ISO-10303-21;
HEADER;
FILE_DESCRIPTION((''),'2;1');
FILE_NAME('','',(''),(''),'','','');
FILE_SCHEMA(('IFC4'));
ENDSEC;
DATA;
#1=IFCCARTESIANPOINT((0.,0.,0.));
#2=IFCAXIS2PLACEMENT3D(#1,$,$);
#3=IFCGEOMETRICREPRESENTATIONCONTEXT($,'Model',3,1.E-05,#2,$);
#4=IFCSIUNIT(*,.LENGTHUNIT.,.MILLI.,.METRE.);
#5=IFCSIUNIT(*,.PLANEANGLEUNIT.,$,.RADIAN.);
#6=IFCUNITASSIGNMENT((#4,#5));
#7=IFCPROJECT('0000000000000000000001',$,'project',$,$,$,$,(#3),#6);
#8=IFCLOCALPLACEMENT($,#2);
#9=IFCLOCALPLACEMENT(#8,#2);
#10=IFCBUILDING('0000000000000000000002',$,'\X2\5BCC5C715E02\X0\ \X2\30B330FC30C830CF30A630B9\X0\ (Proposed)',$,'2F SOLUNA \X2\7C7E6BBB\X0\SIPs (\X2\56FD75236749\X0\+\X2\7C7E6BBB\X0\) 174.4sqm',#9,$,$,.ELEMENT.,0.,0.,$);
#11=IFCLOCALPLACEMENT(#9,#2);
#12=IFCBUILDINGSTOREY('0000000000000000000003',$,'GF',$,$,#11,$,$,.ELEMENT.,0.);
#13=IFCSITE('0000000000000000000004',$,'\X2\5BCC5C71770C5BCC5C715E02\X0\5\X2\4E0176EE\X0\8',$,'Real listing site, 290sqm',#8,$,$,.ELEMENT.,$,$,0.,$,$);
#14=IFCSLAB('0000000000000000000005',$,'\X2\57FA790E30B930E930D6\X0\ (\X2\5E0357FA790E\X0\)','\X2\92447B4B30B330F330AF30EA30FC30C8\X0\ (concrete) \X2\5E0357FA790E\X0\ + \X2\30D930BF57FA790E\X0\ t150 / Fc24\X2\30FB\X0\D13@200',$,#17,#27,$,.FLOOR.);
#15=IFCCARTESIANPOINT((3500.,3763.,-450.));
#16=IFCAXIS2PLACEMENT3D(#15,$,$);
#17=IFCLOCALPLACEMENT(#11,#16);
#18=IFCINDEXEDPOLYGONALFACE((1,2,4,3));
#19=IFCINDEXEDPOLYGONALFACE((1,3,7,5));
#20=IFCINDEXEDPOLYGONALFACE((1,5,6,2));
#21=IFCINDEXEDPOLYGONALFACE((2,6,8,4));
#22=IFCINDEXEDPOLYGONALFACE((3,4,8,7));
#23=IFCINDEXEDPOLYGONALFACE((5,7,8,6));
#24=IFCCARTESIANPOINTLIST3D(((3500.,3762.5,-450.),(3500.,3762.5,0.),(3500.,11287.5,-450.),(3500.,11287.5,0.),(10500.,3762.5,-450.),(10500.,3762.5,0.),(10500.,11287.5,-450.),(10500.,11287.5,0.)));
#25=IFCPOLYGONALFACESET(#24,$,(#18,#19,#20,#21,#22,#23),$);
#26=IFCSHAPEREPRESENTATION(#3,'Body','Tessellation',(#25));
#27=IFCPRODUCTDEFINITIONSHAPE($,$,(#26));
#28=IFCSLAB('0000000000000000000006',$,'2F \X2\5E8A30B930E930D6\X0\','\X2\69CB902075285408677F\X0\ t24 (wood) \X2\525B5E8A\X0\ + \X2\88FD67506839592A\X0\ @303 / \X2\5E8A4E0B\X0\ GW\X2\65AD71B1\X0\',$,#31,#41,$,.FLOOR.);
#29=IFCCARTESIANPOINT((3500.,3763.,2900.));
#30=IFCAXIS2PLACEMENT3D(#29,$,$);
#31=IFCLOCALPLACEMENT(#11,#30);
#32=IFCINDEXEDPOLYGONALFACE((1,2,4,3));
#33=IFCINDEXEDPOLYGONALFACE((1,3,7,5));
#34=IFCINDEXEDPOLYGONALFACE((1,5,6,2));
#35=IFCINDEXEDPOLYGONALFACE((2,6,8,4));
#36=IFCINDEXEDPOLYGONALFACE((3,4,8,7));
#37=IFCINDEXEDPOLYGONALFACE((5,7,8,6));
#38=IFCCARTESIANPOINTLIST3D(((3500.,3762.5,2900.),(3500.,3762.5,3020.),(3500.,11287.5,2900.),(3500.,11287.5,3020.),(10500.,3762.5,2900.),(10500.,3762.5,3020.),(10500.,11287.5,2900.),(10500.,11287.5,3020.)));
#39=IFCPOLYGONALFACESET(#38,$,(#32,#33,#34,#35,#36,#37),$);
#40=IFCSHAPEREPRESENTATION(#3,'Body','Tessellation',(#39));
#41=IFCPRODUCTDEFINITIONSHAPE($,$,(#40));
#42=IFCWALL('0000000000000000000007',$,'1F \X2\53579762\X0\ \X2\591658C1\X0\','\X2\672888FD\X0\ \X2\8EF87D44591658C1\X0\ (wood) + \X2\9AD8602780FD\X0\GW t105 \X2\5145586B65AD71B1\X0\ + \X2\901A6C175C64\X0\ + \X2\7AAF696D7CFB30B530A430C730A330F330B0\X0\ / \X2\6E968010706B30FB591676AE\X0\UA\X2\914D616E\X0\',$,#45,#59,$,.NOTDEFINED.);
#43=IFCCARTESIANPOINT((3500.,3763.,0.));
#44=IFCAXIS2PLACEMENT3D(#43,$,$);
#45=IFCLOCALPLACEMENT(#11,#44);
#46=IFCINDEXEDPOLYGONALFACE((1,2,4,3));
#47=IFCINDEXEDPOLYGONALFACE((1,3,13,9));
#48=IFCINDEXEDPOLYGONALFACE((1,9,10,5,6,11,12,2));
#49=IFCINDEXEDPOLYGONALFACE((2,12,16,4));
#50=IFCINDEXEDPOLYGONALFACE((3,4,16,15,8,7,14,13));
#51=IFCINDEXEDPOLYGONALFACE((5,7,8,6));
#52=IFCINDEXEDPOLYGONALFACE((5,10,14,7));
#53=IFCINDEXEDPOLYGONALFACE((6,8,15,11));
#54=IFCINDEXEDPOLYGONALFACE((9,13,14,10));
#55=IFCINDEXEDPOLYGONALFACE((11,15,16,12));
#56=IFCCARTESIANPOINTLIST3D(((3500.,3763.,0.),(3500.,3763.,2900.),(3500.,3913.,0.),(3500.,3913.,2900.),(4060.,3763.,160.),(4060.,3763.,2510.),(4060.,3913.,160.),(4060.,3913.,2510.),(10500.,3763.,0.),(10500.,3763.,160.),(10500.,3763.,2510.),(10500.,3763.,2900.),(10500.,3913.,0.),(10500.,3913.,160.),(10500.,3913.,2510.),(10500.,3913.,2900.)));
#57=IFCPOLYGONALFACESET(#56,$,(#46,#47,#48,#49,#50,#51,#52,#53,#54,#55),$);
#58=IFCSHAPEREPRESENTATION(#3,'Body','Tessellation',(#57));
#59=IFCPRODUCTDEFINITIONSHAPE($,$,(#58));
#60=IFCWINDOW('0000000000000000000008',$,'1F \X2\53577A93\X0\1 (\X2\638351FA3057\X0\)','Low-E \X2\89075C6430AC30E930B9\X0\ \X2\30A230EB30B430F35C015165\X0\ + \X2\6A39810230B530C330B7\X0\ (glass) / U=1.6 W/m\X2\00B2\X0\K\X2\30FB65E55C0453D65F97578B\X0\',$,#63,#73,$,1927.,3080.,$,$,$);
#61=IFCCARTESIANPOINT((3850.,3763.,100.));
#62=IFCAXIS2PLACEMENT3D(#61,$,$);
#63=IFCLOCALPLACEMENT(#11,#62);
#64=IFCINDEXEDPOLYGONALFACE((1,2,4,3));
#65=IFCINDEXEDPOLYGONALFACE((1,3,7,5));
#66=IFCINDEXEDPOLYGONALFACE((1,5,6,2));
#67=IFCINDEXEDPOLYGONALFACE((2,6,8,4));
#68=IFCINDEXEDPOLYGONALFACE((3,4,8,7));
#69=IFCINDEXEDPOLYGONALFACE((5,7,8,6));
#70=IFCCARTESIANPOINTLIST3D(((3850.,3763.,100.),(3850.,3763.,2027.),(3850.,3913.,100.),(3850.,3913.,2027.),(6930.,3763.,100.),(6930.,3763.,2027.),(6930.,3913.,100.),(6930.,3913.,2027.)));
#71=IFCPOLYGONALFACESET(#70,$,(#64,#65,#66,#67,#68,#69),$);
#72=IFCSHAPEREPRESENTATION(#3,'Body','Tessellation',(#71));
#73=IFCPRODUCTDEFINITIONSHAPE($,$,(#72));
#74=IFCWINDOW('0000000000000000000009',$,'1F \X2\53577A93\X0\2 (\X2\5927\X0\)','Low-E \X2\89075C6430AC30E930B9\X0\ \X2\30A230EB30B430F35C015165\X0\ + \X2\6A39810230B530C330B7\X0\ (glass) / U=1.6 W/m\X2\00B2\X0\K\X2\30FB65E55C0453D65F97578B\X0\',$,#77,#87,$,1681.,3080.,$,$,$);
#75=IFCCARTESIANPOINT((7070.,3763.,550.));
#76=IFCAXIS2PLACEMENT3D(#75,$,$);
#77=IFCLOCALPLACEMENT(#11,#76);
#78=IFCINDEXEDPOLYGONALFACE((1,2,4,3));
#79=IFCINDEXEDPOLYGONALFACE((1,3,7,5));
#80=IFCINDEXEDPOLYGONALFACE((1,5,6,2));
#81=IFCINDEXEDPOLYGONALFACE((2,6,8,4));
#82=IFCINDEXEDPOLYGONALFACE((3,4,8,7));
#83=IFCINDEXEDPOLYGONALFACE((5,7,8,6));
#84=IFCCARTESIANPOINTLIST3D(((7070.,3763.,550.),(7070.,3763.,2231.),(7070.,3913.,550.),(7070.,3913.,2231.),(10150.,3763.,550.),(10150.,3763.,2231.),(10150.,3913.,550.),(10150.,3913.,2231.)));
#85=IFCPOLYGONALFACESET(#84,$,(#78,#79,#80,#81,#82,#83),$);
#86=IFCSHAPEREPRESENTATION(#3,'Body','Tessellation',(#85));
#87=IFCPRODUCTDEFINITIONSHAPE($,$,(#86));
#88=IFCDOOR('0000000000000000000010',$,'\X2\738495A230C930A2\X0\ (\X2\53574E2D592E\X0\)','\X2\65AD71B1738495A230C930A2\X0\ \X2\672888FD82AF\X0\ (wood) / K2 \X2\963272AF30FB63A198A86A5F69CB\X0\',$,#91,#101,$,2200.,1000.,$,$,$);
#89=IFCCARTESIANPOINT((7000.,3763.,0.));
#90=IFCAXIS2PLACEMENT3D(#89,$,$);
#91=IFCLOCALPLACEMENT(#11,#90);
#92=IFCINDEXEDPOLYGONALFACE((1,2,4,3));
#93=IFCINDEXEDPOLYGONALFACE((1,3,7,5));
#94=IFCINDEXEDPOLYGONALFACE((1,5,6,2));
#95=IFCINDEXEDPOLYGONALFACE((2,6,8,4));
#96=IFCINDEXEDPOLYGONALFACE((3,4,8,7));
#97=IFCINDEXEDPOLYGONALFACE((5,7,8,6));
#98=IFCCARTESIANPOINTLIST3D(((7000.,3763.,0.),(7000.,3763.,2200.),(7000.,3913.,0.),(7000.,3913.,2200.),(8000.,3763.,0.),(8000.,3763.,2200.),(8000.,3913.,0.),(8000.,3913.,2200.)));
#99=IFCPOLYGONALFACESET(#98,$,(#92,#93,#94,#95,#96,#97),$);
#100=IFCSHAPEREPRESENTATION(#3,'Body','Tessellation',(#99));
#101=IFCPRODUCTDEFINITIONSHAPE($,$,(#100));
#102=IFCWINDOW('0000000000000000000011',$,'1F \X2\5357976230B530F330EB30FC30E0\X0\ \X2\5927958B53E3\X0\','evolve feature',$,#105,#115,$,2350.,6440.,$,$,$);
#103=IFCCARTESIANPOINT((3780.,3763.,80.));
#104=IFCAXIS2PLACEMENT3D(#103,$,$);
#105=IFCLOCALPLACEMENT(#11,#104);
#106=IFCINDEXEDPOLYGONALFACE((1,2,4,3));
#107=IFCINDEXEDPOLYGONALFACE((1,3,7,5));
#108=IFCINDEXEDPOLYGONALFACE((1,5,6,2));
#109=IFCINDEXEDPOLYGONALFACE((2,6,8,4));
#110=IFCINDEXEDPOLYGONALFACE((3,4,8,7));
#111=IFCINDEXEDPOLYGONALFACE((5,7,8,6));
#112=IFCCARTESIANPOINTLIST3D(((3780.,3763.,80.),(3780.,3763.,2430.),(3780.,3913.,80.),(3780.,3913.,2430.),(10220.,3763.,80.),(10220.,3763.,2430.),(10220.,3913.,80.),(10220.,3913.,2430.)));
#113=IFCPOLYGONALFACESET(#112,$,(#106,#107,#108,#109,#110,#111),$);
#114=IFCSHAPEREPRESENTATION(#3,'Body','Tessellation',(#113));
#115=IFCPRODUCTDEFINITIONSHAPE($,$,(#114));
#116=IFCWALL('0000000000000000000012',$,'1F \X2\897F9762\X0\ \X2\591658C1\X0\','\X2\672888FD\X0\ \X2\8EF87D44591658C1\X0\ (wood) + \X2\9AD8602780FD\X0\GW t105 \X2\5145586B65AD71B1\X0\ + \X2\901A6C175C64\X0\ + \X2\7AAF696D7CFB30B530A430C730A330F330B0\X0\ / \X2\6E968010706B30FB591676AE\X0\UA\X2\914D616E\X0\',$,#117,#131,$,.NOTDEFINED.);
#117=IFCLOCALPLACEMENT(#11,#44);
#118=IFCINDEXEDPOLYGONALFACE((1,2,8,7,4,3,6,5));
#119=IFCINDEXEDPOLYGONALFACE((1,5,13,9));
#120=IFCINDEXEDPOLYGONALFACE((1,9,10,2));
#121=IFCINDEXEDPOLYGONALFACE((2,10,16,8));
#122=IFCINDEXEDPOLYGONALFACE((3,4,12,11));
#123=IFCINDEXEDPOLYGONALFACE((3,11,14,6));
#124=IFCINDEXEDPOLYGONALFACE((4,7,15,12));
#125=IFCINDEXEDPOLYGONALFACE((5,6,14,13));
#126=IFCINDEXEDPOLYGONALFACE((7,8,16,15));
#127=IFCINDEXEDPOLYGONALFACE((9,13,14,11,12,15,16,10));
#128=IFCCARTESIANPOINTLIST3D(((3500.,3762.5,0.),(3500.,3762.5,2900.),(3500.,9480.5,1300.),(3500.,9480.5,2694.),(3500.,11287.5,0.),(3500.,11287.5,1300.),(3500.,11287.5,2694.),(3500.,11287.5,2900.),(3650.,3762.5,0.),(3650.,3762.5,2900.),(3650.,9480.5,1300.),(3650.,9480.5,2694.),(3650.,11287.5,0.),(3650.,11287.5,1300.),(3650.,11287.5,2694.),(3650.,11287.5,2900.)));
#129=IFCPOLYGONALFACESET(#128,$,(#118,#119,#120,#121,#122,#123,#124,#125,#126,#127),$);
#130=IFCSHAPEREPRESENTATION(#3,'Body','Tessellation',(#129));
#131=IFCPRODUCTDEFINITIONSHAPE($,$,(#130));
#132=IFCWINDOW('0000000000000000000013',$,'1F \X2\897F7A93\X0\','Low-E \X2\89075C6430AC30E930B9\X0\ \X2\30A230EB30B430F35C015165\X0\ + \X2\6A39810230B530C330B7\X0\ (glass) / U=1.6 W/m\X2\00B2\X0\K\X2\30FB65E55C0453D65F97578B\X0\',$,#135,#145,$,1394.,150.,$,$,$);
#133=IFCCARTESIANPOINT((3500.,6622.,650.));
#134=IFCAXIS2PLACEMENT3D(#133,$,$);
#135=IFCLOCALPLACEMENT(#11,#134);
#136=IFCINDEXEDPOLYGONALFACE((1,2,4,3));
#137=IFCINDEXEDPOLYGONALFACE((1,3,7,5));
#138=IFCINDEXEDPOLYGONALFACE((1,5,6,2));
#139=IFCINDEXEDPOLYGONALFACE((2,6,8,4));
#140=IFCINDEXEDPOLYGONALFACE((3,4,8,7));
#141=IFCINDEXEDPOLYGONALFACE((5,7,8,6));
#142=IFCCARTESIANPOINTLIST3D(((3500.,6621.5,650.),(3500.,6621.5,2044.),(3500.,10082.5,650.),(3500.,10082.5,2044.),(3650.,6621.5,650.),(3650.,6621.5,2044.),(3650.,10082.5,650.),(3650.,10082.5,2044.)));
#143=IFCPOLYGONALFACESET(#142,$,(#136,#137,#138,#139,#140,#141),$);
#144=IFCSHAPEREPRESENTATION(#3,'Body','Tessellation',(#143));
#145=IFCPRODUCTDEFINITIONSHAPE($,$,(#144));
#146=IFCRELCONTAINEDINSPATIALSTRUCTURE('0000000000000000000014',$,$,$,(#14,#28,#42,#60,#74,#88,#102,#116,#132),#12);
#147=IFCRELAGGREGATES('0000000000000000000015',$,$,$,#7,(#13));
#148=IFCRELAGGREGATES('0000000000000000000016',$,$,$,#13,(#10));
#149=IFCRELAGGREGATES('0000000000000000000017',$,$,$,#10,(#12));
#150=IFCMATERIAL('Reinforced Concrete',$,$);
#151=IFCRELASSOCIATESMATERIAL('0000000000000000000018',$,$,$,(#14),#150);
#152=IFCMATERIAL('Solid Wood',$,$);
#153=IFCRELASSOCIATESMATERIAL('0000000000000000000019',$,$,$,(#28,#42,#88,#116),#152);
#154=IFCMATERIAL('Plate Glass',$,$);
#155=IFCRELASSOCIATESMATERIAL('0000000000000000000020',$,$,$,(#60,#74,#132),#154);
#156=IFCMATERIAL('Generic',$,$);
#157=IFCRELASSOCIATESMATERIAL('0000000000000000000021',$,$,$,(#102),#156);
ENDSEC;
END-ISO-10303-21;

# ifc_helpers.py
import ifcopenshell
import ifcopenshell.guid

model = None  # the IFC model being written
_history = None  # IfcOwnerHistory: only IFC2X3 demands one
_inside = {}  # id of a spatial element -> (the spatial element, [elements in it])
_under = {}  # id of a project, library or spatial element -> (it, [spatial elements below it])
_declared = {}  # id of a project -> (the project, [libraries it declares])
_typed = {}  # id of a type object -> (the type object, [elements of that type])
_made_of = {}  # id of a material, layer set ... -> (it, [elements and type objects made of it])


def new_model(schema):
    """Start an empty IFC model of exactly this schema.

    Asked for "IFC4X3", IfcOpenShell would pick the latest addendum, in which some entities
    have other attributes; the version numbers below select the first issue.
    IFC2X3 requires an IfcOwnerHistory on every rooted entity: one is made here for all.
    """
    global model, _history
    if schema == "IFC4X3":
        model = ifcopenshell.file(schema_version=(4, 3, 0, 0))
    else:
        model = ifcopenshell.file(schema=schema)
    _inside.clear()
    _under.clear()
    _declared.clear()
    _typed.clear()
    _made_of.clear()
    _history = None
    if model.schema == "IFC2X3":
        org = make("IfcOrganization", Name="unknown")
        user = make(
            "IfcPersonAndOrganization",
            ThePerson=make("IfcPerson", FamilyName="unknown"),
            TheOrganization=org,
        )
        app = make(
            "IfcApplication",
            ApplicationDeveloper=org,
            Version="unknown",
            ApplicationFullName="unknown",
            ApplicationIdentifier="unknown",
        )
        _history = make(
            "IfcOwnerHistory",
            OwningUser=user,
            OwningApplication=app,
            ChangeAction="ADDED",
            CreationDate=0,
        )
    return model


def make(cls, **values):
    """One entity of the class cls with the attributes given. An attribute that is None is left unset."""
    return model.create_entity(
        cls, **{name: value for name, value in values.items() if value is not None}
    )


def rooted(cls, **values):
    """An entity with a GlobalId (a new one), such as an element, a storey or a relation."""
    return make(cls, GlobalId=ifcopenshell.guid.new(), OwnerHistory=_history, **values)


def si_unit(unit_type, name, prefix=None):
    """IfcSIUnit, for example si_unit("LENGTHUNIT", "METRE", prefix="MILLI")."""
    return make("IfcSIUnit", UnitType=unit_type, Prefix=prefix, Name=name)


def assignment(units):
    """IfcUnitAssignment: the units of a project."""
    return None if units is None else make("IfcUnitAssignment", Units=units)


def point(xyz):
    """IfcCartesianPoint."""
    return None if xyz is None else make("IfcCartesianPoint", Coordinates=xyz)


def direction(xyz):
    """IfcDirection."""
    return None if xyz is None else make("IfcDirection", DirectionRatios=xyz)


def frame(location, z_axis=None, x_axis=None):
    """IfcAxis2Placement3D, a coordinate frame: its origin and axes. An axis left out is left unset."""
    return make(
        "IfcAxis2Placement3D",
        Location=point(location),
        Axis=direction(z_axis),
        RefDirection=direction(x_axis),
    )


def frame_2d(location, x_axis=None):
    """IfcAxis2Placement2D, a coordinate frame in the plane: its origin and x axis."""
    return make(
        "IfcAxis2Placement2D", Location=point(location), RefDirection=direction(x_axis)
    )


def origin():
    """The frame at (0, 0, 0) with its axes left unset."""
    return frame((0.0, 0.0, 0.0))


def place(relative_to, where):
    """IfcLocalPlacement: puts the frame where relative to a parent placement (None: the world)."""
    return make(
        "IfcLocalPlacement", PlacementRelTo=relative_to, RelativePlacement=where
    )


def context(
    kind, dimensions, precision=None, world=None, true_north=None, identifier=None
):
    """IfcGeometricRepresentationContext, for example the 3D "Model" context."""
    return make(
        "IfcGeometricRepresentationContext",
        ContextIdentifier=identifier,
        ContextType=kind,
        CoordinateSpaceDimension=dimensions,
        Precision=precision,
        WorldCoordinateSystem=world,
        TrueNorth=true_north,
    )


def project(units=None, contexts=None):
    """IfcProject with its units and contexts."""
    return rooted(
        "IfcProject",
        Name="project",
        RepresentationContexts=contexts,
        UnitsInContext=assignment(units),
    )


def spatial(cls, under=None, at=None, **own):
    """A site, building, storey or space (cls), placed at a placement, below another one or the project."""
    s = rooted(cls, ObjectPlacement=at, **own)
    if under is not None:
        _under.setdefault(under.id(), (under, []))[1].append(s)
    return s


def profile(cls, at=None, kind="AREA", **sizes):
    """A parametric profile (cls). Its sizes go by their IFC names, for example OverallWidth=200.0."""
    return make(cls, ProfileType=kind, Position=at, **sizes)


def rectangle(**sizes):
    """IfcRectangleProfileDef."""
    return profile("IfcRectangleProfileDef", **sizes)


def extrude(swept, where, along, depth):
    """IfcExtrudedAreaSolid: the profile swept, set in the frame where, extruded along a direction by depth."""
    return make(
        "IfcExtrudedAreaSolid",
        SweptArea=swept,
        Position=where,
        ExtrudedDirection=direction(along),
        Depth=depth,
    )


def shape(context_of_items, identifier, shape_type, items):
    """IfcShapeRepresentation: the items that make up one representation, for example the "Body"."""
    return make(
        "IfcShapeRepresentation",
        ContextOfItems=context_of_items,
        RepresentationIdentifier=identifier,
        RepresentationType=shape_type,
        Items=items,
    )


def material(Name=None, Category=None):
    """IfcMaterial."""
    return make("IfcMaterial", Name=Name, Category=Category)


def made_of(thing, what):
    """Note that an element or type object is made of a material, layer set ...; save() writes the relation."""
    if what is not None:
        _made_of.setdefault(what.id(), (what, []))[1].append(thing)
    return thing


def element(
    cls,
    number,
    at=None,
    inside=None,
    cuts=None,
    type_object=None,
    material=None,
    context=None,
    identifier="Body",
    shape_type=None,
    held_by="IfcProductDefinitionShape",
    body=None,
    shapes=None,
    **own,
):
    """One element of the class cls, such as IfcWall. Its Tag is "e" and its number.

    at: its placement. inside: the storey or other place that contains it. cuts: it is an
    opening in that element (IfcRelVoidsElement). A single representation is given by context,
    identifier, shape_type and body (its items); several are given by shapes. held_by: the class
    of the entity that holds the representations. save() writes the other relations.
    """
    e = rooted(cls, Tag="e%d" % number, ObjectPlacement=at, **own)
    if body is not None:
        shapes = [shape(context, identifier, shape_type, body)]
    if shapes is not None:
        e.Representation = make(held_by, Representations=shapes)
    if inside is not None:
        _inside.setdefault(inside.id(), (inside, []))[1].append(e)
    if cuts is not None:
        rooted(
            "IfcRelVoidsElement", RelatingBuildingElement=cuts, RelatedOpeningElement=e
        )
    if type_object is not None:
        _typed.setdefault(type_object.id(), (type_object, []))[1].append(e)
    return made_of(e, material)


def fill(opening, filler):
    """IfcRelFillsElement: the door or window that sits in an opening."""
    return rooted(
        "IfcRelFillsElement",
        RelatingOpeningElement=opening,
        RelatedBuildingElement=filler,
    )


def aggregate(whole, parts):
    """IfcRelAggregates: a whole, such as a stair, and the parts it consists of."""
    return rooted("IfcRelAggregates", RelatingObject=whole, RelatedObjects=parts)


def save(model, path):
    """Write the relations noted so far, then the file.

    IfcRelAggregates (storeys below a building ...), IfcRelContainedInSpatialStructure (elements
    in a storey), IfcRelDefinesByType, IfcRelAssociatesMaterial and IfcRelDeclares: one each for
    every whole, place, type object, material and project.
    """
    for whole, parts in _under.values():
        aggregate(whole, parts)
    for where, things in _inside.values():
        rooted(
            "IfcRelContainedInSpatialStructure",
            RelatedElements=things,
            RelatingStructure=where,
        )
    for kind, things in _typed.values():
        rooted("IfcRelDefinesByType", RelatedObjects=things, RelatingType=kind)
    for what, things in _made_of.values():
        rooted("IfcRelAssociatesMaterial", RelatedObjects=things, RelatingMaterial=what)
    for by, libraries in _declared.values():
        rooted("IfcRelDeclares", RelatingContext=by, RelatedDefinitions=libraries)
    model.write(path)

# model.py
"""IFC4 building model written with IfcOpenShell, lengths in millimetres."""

from ifc_helpers import new_model, si_unit, frame, frame_2d, origin, place, context, project, spatial, rectangle, extrude, material, element, fill, save


model = new_model("IFC4")

# Units and contexts
model_context = context("Model", 3, precision=1e-05, world=origin())
ifc_project = project(units=[si_unit("LENGTHUNIT", "METRE", prefix="MILLI"), si_unit("PLANEANGLEUNIT", "RADIAN")], contexts=[model_context])

# Site, building, storey
site_placement = place(None, origin())
site = spatial("IfcSite", under=ifc_project, at=site_placement, Name="富山県富山市5丁目8", ObjectType="Real listing site, 290sqm", CompositionType="ELEMENT", RefElevation=0.0)
building_placement = place(site_placement, origin())
building = spatial("IfcBuilding", under=site, at=building_placement, Name="富山市 コートハウス (Proposed)", ObjectType="2F SOLUNA 籾殻SIPs (国産杉+籾殻) 174.4sqm", CompositionType="ELEMENT", ElevationOfRefHeight=0.0, ElevationOfTerrain=0.0)
storey_placement = place(building_placement, origin())
storey = spatial("IfcBuildingStorey", under=building, at=storey_placement, Name="GF", CompositionType="ELEMENT", Elevation=0.0)

# Slabs
ifc_material_1 = material(Name="Reinforced Concrete")
slab_1_placement = place(storey_placement, frame((3500.0, 3763.0, -450.0)))
element("IfcSlab", 1, at=slab_1_placement, inside=storey, material=ifc_material_1, Name="基礎スラブ (布基礎)", Description="鉄筋コンクリート (concrete) 布基礎 + ベタ基礎 t150 / Fc24・D13@200", PredefinedType="FLOOR", context=model_context, shape_type="SweptSolid", body=[
    extrude(rectangle(XDim=7000.0, YDim=7525.0, at=frame_2d((3500.0, 3762.0))), frame((3500.0, 3763.0, -450.0)), (0.0, 0.0, 1.0), 450.0),
])
ifc_material_2 = material(Name="Solid Wood")
slab_2_placement = place(storey_placement, frame((3500.0, 3763.0, 2900.0)))
element("IfcSlab", 2, at=slab_2_placement, inside=storey, material=ifc_material_2, Name="2F 床スラブ", Description="構造用合板 t24 (wood) 剛床 + 製材根太 @303 / 床下 GW断熱", PredefinedType="FLOOR", context=model_context, shape_type="SweptSolid", body=[
    extrude(rectangle(XDim=7000.0, YDim=7525.0, at=frame_2d((3500.0, 3762.0))), frame((3500.0, 3763.0, 2900.0)), (0.0, 0.0, 1.0), 120.0),
])
ifc_material_3 = material(Name="Generic")

# Wall, openings, windows, door
wall_1_placement = place(storey_placement, frame((3500.0, 3763.0, 0.0)))
wall_1 = element("IfcWall", 3, at=wall_1_placement, inside=storey, material=ifc_material_2, Name="1F 南面 外壁", Description="木製 軸組外壁 (wood) + 高性能GW t105 充填断熱 + 通気層 + 窯業系サイディング / 準耐火・外皮UA配慮", PredefinedType="NOTDEFINED", context=model_context, shape_type="SweptSolid", body=[
    extrude(rectangle(XDim=7000.0, YDim=150.0, at=frame_2d((3500.0, 75.0))), frame((3500.0, 3763.0, 0.0)), (0.0, 0.0, 1.0), 2900.0),
])
opening_1_placement = place(storey_placement, frame((3850.0, 3763.0, 100.0)))
opening_1 = element("IfcOpeningElement", 4, at=opening_1_placement, cuts=wall_1, PredefinedType="NOTDEFINED", context=model_context, shape_type="SweptSolid", body=[
    extrude(rectangle(XDim=3080.0, YDim=150.0, at=frame_2d((1540.0, 75.0))), frame((3850.0, 3763.0, 100.0)), (0.0, 0.0, 1.0), 1927.0),
])
opening_2_placement = place(storey_placement, frame((7070.0, 3763.0, 550.0)))
opening_2 = element("IfcOpeningElement", 5, at=opening_2_placement, cuts=wall_1, PredefinedType="NOTDEFINED", context=model_context, shape_type="SweptSolid", body=[
    extrude(rectangle(XDim=3080.0, YDim=150.0, at=frame_2d((1540.0, 75.0))), frame((7070.0, 3763.0, 550.0)), (0.0, 0.0, 1.0), 1681.0),
])
opening_3_placement = place(storey_placement, frame((7000.0, 3763.0, 0.0)))
opening_3 = element("IfcOpeningElement", 6, at=opening_3_placement, cuts=wall_1, PredefinedType="NOTDEFINED", context=model_context, shape_type="SweptSolid", body=[
    extrude(rectangle(XDim=1000.0, YDim=150.0, at=frame_2d((500.0, 75.0))), frame((7000.0, 3763.0, 0.0)), (0.0, 0.0, 1.0), 2200.0),
])
opening_4_placement = place(storey_placement, frame((3780.0, 3763.0, 80.0)))
opening_4 = element("IfcOpeningElement", 7, at=opening_4_placement, cuts=wall_1, PredefinedType="NOTDEFINED", context=model_context, shape_type="SweptSolid", body=[
    extrude(rectangle(XDim=6440.0, YDim=150.0, at=frame_2d((3220.0, 75.0))), frame((3780.0, 3763.0, 80.0)), (0.0, 0.0, 1.0), 2350.0),
])
ifc_material_4 = material(Name="Plate Glass")
window_1_placement = place(storey_placement, frame((3850.0, 3763.0, 100.0)))
window_1 = element("IfcWindow", 8, at=window_1_placement, inside=storey, material=ifc_material_4, Name="1F 南窓1 (掃出し)", Description="Low-E 複層ガラス アルゴン封入 + 樹脂サッシ (glass) / U=1.6 W/m²K・日射取得型", OverallHeight=1927.0, OverallWidth=3080.0, context=model_context, shape_type="SweptSolid", body=[
    extrude(rectangle(XDim=3080.0, YDim=150.0, at=frame_2d((1540.0, 75.0))), frame((3850.0, 3763.0, 100.0)), (0.0, 0.0, 1.0), 1927.0),
])
fill(opening_1, window_1)
window_2_placement = place(storey_placement, frame((7070.0, 3763.0, 550.0)))
window_2 = element("IfcWindow", 9, at=window_2_placement, inside=storey, material=ifc_material_4, Name="1F 南窓2 (大)", Description="Low-E 複層ガラス アルゴン封入 + 樹脂サッシ (glass) / U=1.6 W/m²K・日射取得型", OverallHeight=1681.0, OverallWidth=3080.0, context=model_context, shape_type="SweptSolid", body=[
    extrude(rectangle(XDim=3080.0, YDim=150.0, at=frame_2d((1540.0, 75.0))), frame((7070.0, 3763.0, 550.0)), (0.0, 0.0, 1.0), 1681.0),
])
fill(opening_2, window_2)
door_placement = place(storey_placement, frame((7000.0, 3763.0, 0.0)))
door = element("IfcDoor", 10, at=door_placement, inside=storey, material=ifc_material_2, Name="玄関ドア (南中央)", Description="断熱玄関ドア 木製芯 (wood) / K2 防犯・採風機構", OverallHeight=2200.0, OverallWidth=1000.0, context=model_context, shape_type="SweptSolid", body=[
    extrude(rectangle(XDim=1000.0, YDim=150.0, at=frame_2d((500.0, 75.0))), frame((7000.0, 3763.0, 0.0)), (0.0, 0.0, 1.0), 2200.0),
])
fill(opening_3, door)
window_3_placement = place(storey_placement, frame((3780.0, 3763.0, 80.0)))
window_3 = element("IfcWindow", 11, at=window_3_placement, inside=storey, material=ifc_material_3, Name="1F 南面サンルーム 大開口", Description="evolve feature", OverallHeight=2350.0, OverallWidth=6440.0, context=model_context, shape_type="SweptSolid", body=[
    extrude(rectangle(XDim=6440.0, YDim=150.0, at=frame_2d((3220.0, 75.0))), frame((3780.0, 3763.0, 80.0)), (0.0, 0.0, 1.0), 2350.0),
])
fill(opening_4, window_3)

# Wall, opening, window
wall_2_placement = place(storey_placement, frame((3500.0, 3763.0, 0.0)))
wall_2 = element("IfcWall", 12, at=wall_2_placement, inside=storey, material=ifc_material_2, Name="1F 西面 外壁", Description="木製 軸組外壁 (wood) + 高性能GW t105 充填断熱 + 通気層 + 窯業系サイディング / 準耐火・外皮UA配慮", PredefinedType="NOTDEFINED", context=model_context, shape_type="SweptSolid", body=[
    extrude(rectangle(XDim=150.0, YDim=7525.0, at=frame_2d((75.0, 3762.0))), frame((3500.0, 3763.0, 0.0)), (0.0, 0.0, 1.0), 2900.0),
])
opening_5_placement = place(storey_placement, frame((3500.0, 6622.0, 650.0)))
opening_5 = element("IfcOpeningElement", 13, at=opening_5_placement, cuts=wall_2, PredefinedType="NOTDEFINED", context=model_context, shape_type="SweptSolid", body=[
    extrude(rectangle(XDim=150.0, YDim=3461.0, at=frame_2d((75.0, 1730.0))), frame((3500.0, 6622.0, 650.0)), (0.0, 0.0, 1.0), 1394.0),
])
window_4_placement = place(storey_placement, frame((3500.0, 6622.0, 650.0)))
window_4 = element("IfcWindow", 14, at=window_4_placement, inside=storey, material=ifc_material_4, Name="1F 西窓", Description="Low-E 複層ガラス アルゴン封入 + 樹脂サッシ (glass) / U=1.6 W/m²K・日射取得型", OverallHeight=1394.0, OverallWidth=150.0, context=model_context, shape_type="SweptSolid", body=[
    extrude(rectangle(XDim=150.0, YDim=3461.0, at=frame_2d((75.0, 1730.0))), frame((3500.0, 6622.0, 650.0)), (0.0, 0.0, 1.0), 1394.0),
])
fill(opening_5, window_4)

save(model, "model.ifc")
